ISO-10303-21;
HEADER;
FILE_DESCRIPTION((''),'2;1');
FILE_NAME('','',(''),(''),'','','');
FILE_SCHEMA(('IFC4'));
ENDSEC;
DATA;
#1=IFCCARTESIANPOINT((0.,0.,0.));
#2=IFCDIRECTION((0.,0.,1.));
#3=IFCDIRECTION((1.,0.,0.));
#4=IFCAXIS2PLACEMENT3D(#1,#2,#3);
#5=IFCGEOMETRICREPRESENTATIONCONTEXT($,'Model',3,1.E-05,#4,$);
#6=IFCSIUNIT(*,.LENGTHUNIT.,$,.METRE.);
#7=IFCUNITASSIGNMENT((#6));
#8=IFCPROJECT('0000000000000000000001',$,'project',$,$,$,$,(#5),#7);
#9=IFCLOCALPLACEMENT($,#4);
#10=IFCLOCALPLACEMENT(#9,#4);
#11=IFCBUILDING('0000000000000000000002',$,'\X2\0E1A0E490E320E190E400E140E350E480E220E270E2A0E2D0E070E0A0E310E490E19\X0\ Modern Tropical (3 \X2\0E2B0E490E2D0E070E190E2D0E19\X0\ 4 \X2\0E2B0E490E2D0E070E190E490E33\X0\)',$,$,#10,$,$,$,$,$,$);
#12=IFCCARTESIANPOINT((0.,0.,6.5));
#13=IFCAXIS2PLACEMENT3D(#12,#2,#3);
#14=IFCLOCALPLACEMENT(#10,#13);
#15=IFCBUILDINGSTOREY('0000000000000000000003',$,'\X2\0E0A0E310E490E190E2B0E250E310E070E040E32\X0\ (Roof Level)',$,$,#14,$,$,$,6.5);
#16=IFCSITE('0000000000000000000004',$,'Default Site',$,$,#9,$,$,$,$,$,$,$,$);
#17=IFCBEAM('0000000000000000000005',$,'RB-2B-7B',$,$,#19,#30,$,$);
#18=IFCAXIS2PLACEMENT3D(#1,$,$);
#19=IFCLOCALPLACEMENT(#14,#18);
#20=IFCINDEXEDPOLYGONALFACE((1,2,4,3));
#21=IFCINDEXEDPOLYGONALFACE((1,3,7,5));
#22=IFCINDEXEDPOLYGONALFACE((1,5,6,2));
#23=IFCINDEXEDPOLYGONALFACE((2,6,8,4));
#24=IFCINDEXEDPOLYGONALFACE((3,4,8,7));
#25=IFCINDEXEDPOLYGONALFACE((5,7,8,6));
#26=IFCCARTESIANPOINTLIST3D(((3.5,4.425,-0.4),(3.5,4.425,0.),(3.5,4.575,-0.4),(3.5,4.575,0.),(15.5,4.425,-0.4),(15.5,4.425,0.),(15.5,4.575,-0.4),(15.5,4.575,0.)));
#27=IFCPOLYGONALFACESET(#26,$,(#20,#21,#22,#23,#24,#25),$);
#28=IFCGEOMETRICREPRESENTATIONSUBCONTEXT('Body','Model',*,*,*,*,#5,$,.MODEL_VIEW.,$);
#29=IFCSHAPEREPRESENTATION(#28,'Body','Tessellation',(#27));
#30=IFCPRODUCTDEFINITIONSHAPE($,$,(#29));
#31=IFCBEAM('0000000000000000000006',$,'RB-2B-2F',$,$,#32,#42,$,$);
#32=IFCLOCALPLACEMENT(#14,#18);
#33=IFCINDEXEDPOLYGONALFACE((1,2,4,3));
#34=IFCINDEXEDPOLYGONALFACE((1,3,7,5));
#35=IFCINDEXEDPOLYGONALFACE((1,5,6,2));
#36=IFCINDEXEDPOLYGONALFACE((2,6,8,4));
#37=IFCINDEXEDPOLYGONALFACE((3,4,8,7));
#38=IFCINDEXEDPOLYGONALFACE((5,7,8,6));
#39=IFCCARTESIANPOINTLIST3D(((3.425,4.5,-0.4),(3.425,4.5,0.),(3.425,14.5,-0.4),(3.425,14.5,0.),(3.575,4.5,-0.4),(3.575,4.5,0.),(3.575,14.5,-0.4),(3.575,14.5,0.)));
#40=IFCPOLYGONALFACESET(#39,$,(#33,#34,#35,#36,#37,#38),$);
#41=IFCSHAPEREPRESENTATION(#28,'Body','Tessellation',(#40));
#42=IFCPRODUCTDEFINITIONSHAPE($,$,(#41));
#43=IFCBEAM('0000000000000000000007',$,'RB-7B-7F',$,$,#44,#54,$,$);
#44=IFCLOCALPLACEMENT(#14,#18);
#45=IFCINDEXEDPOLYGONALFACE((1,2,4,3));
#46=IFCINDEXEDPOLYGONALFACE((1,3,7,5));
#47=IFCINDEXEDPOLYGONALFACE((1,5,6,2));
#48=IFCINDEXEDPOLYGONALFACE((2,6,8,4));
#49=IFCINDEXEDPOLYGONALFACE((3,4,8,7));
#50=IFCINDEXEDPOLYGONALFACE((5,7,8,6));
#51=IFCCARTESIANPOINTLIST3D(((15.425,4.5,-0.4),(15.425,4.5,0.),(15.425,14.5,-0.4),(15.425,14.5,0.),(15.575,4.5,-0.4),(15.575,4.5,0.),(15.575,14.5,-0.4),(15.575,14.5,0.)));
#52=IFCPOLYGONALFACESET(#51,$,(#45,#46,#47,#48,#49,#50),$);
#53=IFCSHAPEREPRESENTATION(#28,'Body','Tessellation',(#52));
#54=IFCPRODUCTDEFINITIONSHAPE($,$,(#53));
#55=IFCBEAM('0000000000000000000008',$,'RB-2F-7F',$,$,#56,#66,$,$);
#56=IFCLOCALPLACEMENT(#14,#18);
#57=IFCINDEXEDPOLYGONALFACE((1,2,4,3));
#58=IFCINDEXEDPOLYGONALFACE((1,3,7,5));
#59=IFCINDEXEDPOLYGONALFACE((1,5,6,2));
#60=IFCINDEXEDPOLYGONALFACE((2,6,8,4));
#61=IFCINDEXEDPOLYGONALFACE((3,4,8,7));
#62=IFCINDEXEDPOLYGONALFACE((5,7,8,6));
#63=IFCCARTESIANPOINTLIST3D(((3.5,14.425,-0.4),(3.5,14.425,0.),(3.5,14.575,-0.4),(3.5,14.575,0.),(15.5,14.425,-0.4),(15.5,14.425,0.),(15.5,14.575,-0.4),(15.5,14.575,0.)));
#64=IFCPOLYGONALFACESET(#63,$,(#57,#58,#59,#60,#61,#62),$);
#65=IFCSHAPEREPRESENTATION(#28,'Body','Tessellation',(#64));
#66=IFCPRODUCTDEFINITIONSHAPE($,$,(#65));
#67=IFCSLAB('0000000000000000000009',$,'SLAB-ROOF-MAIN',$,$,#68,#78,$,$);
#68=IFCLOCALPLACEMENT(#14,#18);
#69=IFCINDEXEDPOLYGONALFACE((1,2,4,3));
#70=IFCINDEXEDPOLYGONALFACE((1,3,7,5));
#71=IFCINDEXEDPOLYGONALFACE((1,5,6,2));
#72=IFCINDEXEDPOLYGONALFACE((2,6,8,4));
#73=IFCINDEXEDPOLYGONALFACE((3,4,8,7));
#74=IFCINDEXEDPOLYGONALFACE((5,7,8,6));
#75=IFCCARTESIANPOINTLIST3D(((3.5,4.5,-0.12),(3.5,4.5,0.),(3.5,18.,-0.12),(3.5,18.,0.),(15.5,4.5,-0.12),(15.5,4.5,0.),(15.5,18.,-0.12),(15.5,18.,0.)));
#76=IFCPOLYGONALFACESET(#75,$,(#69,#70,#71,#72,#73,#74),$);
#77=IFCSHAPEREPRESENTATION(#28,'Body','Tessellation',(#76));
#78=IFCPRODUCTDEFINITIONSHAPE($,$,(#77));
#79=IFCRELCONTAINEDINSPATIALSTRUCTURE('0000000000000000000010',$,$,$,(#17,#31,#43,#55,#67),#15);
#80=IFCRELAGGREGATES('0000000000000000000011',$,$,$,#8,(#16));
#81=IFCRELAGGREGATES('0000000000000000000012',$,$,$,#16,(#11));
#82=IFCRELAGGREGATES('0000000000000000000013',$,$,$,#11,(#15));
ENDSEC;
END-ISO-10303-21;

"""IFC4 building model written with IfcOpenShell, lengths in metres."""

from ifc_helpers import new_model, si_unit, frame, origin_with_axes, origin_2d, place, context, subcontext, project, spatial, polyline, rectangle, outline, extrude, element, save


model = new_model("IFC4")

# Units and contexts
model_context = context("Model", 3, precision=1e-05, world=origin_with_axes())
body_context = subcontext(model_context, "Body", "Model", "MODEL_VIEW")
ifc_project = project(units=[si_unit("LENGTHUNIT", "METRE")], contexts=[model_context])

# Site, building, storey
site_placement = place(None, origin_with_axes())
site = spatial("IfcSite", under=ifc_project, at=site_placement, Name="Default Site")
building_placement = place(site_placement, origin_with_axes())
building = spatial("IfcBuilding", under=site, at=building_placement, Name="บ้านเดี่ยวสองชั้น Modern Tropical (3 ห้องนอน 4 ห้องน้ำ)")
storey_placement = place(building_placement, frame((0.0, 0.0, 6.5), z_axis=(0.0, 0.0, 1.0), x_axis=(1.0, 0.0, 0.0)))
storey = spatial("IfcBuildingStorey", under=building, at=storey_placement, Name="ชั้นหลังคา (Roof Level)", Elevation=6.5)

# Beams
beam_1_placement = place(storey_placement, frame((3.5, 4.5, -0.2), z_axis=(1.0, 0.0, 0.0), x_axis=(0.0, 1.0, 0.0)))
element("IfcBeam", 1, at=beam_1_placement, inside=storey, Name="RB-2B-7B", context=body_context, shape_type="SweptSolid", body=[
    extrude(rectangle(XDim=0.15, YDim=0.4, at=origin_2d()), origin_with_axes(), (0.0, 0.0, 1.0), 12.0),
])
for number, where, z_axis, x_axis, name in (
    (2, (3.5, 4.5, -0.2), (0.0, 1.0, 0.0), (-1.0, 0.0, 0.0), "RB-2B-2F"),
    (3, (15.5, 4.5, -0.2), (0.0, 1.0, 0.0), (-1.0, 0.0, 0.0), "RB-7B-7F"),
):
    element("IfcBeam", number, at=place(storey_placement, frame(where, z_axis=z_axis, x_axis=x_axis)), inside=storey, Name=name, context=body_context, shape_type="SweptSolid", body=[
        extrude(rectangle(XDim=0.15, YDim=0.4, at=origin_2d()), origin_with_axes(), (0.0, 0.0, 1.0), 10.0),
    ])
beam_2_placement = place(storey_placement, frame((3.5, 14.5, -0.2), z_axis=(1.0, 0.0, 0.0), x_axis=(0.0, 1.0, 0.0)))
element("IfcBeam", 4, at=beam_2_placement, inside=storey, Name="RB-2F-7F", context=body_context, shape_type="SweptSolid", body=[
    extrude(rectangle(XDim=0.15, YDim=0.4, at=origin_2d()), origin_with_axes(), (0.0, 0.0, 1.0), 12.0),
])

# Slab
slab_placement = place(storey_placement, frame((0.0, 0.0, -0.12), z_axis=(0.0, 0.0, 1.0), x_axis=(1.0, 0.0, 0.0)))
element("IfcSlab", 5, at=slab_placement, inside=storey, Name="SLAB-ROOF-MAIN", context=body_context, shape_type="SweptSolid", body=[
    extrude(outline(polyline([(3.5, 4.5), (15.5, 4.5), (15.5, 18.0), (3.5, 18.0), (3.5, 4.5)])), origin_with_axes(), (0.0, 0.0, 1.0), 0.12),
])

save(model, "model.ifc")
